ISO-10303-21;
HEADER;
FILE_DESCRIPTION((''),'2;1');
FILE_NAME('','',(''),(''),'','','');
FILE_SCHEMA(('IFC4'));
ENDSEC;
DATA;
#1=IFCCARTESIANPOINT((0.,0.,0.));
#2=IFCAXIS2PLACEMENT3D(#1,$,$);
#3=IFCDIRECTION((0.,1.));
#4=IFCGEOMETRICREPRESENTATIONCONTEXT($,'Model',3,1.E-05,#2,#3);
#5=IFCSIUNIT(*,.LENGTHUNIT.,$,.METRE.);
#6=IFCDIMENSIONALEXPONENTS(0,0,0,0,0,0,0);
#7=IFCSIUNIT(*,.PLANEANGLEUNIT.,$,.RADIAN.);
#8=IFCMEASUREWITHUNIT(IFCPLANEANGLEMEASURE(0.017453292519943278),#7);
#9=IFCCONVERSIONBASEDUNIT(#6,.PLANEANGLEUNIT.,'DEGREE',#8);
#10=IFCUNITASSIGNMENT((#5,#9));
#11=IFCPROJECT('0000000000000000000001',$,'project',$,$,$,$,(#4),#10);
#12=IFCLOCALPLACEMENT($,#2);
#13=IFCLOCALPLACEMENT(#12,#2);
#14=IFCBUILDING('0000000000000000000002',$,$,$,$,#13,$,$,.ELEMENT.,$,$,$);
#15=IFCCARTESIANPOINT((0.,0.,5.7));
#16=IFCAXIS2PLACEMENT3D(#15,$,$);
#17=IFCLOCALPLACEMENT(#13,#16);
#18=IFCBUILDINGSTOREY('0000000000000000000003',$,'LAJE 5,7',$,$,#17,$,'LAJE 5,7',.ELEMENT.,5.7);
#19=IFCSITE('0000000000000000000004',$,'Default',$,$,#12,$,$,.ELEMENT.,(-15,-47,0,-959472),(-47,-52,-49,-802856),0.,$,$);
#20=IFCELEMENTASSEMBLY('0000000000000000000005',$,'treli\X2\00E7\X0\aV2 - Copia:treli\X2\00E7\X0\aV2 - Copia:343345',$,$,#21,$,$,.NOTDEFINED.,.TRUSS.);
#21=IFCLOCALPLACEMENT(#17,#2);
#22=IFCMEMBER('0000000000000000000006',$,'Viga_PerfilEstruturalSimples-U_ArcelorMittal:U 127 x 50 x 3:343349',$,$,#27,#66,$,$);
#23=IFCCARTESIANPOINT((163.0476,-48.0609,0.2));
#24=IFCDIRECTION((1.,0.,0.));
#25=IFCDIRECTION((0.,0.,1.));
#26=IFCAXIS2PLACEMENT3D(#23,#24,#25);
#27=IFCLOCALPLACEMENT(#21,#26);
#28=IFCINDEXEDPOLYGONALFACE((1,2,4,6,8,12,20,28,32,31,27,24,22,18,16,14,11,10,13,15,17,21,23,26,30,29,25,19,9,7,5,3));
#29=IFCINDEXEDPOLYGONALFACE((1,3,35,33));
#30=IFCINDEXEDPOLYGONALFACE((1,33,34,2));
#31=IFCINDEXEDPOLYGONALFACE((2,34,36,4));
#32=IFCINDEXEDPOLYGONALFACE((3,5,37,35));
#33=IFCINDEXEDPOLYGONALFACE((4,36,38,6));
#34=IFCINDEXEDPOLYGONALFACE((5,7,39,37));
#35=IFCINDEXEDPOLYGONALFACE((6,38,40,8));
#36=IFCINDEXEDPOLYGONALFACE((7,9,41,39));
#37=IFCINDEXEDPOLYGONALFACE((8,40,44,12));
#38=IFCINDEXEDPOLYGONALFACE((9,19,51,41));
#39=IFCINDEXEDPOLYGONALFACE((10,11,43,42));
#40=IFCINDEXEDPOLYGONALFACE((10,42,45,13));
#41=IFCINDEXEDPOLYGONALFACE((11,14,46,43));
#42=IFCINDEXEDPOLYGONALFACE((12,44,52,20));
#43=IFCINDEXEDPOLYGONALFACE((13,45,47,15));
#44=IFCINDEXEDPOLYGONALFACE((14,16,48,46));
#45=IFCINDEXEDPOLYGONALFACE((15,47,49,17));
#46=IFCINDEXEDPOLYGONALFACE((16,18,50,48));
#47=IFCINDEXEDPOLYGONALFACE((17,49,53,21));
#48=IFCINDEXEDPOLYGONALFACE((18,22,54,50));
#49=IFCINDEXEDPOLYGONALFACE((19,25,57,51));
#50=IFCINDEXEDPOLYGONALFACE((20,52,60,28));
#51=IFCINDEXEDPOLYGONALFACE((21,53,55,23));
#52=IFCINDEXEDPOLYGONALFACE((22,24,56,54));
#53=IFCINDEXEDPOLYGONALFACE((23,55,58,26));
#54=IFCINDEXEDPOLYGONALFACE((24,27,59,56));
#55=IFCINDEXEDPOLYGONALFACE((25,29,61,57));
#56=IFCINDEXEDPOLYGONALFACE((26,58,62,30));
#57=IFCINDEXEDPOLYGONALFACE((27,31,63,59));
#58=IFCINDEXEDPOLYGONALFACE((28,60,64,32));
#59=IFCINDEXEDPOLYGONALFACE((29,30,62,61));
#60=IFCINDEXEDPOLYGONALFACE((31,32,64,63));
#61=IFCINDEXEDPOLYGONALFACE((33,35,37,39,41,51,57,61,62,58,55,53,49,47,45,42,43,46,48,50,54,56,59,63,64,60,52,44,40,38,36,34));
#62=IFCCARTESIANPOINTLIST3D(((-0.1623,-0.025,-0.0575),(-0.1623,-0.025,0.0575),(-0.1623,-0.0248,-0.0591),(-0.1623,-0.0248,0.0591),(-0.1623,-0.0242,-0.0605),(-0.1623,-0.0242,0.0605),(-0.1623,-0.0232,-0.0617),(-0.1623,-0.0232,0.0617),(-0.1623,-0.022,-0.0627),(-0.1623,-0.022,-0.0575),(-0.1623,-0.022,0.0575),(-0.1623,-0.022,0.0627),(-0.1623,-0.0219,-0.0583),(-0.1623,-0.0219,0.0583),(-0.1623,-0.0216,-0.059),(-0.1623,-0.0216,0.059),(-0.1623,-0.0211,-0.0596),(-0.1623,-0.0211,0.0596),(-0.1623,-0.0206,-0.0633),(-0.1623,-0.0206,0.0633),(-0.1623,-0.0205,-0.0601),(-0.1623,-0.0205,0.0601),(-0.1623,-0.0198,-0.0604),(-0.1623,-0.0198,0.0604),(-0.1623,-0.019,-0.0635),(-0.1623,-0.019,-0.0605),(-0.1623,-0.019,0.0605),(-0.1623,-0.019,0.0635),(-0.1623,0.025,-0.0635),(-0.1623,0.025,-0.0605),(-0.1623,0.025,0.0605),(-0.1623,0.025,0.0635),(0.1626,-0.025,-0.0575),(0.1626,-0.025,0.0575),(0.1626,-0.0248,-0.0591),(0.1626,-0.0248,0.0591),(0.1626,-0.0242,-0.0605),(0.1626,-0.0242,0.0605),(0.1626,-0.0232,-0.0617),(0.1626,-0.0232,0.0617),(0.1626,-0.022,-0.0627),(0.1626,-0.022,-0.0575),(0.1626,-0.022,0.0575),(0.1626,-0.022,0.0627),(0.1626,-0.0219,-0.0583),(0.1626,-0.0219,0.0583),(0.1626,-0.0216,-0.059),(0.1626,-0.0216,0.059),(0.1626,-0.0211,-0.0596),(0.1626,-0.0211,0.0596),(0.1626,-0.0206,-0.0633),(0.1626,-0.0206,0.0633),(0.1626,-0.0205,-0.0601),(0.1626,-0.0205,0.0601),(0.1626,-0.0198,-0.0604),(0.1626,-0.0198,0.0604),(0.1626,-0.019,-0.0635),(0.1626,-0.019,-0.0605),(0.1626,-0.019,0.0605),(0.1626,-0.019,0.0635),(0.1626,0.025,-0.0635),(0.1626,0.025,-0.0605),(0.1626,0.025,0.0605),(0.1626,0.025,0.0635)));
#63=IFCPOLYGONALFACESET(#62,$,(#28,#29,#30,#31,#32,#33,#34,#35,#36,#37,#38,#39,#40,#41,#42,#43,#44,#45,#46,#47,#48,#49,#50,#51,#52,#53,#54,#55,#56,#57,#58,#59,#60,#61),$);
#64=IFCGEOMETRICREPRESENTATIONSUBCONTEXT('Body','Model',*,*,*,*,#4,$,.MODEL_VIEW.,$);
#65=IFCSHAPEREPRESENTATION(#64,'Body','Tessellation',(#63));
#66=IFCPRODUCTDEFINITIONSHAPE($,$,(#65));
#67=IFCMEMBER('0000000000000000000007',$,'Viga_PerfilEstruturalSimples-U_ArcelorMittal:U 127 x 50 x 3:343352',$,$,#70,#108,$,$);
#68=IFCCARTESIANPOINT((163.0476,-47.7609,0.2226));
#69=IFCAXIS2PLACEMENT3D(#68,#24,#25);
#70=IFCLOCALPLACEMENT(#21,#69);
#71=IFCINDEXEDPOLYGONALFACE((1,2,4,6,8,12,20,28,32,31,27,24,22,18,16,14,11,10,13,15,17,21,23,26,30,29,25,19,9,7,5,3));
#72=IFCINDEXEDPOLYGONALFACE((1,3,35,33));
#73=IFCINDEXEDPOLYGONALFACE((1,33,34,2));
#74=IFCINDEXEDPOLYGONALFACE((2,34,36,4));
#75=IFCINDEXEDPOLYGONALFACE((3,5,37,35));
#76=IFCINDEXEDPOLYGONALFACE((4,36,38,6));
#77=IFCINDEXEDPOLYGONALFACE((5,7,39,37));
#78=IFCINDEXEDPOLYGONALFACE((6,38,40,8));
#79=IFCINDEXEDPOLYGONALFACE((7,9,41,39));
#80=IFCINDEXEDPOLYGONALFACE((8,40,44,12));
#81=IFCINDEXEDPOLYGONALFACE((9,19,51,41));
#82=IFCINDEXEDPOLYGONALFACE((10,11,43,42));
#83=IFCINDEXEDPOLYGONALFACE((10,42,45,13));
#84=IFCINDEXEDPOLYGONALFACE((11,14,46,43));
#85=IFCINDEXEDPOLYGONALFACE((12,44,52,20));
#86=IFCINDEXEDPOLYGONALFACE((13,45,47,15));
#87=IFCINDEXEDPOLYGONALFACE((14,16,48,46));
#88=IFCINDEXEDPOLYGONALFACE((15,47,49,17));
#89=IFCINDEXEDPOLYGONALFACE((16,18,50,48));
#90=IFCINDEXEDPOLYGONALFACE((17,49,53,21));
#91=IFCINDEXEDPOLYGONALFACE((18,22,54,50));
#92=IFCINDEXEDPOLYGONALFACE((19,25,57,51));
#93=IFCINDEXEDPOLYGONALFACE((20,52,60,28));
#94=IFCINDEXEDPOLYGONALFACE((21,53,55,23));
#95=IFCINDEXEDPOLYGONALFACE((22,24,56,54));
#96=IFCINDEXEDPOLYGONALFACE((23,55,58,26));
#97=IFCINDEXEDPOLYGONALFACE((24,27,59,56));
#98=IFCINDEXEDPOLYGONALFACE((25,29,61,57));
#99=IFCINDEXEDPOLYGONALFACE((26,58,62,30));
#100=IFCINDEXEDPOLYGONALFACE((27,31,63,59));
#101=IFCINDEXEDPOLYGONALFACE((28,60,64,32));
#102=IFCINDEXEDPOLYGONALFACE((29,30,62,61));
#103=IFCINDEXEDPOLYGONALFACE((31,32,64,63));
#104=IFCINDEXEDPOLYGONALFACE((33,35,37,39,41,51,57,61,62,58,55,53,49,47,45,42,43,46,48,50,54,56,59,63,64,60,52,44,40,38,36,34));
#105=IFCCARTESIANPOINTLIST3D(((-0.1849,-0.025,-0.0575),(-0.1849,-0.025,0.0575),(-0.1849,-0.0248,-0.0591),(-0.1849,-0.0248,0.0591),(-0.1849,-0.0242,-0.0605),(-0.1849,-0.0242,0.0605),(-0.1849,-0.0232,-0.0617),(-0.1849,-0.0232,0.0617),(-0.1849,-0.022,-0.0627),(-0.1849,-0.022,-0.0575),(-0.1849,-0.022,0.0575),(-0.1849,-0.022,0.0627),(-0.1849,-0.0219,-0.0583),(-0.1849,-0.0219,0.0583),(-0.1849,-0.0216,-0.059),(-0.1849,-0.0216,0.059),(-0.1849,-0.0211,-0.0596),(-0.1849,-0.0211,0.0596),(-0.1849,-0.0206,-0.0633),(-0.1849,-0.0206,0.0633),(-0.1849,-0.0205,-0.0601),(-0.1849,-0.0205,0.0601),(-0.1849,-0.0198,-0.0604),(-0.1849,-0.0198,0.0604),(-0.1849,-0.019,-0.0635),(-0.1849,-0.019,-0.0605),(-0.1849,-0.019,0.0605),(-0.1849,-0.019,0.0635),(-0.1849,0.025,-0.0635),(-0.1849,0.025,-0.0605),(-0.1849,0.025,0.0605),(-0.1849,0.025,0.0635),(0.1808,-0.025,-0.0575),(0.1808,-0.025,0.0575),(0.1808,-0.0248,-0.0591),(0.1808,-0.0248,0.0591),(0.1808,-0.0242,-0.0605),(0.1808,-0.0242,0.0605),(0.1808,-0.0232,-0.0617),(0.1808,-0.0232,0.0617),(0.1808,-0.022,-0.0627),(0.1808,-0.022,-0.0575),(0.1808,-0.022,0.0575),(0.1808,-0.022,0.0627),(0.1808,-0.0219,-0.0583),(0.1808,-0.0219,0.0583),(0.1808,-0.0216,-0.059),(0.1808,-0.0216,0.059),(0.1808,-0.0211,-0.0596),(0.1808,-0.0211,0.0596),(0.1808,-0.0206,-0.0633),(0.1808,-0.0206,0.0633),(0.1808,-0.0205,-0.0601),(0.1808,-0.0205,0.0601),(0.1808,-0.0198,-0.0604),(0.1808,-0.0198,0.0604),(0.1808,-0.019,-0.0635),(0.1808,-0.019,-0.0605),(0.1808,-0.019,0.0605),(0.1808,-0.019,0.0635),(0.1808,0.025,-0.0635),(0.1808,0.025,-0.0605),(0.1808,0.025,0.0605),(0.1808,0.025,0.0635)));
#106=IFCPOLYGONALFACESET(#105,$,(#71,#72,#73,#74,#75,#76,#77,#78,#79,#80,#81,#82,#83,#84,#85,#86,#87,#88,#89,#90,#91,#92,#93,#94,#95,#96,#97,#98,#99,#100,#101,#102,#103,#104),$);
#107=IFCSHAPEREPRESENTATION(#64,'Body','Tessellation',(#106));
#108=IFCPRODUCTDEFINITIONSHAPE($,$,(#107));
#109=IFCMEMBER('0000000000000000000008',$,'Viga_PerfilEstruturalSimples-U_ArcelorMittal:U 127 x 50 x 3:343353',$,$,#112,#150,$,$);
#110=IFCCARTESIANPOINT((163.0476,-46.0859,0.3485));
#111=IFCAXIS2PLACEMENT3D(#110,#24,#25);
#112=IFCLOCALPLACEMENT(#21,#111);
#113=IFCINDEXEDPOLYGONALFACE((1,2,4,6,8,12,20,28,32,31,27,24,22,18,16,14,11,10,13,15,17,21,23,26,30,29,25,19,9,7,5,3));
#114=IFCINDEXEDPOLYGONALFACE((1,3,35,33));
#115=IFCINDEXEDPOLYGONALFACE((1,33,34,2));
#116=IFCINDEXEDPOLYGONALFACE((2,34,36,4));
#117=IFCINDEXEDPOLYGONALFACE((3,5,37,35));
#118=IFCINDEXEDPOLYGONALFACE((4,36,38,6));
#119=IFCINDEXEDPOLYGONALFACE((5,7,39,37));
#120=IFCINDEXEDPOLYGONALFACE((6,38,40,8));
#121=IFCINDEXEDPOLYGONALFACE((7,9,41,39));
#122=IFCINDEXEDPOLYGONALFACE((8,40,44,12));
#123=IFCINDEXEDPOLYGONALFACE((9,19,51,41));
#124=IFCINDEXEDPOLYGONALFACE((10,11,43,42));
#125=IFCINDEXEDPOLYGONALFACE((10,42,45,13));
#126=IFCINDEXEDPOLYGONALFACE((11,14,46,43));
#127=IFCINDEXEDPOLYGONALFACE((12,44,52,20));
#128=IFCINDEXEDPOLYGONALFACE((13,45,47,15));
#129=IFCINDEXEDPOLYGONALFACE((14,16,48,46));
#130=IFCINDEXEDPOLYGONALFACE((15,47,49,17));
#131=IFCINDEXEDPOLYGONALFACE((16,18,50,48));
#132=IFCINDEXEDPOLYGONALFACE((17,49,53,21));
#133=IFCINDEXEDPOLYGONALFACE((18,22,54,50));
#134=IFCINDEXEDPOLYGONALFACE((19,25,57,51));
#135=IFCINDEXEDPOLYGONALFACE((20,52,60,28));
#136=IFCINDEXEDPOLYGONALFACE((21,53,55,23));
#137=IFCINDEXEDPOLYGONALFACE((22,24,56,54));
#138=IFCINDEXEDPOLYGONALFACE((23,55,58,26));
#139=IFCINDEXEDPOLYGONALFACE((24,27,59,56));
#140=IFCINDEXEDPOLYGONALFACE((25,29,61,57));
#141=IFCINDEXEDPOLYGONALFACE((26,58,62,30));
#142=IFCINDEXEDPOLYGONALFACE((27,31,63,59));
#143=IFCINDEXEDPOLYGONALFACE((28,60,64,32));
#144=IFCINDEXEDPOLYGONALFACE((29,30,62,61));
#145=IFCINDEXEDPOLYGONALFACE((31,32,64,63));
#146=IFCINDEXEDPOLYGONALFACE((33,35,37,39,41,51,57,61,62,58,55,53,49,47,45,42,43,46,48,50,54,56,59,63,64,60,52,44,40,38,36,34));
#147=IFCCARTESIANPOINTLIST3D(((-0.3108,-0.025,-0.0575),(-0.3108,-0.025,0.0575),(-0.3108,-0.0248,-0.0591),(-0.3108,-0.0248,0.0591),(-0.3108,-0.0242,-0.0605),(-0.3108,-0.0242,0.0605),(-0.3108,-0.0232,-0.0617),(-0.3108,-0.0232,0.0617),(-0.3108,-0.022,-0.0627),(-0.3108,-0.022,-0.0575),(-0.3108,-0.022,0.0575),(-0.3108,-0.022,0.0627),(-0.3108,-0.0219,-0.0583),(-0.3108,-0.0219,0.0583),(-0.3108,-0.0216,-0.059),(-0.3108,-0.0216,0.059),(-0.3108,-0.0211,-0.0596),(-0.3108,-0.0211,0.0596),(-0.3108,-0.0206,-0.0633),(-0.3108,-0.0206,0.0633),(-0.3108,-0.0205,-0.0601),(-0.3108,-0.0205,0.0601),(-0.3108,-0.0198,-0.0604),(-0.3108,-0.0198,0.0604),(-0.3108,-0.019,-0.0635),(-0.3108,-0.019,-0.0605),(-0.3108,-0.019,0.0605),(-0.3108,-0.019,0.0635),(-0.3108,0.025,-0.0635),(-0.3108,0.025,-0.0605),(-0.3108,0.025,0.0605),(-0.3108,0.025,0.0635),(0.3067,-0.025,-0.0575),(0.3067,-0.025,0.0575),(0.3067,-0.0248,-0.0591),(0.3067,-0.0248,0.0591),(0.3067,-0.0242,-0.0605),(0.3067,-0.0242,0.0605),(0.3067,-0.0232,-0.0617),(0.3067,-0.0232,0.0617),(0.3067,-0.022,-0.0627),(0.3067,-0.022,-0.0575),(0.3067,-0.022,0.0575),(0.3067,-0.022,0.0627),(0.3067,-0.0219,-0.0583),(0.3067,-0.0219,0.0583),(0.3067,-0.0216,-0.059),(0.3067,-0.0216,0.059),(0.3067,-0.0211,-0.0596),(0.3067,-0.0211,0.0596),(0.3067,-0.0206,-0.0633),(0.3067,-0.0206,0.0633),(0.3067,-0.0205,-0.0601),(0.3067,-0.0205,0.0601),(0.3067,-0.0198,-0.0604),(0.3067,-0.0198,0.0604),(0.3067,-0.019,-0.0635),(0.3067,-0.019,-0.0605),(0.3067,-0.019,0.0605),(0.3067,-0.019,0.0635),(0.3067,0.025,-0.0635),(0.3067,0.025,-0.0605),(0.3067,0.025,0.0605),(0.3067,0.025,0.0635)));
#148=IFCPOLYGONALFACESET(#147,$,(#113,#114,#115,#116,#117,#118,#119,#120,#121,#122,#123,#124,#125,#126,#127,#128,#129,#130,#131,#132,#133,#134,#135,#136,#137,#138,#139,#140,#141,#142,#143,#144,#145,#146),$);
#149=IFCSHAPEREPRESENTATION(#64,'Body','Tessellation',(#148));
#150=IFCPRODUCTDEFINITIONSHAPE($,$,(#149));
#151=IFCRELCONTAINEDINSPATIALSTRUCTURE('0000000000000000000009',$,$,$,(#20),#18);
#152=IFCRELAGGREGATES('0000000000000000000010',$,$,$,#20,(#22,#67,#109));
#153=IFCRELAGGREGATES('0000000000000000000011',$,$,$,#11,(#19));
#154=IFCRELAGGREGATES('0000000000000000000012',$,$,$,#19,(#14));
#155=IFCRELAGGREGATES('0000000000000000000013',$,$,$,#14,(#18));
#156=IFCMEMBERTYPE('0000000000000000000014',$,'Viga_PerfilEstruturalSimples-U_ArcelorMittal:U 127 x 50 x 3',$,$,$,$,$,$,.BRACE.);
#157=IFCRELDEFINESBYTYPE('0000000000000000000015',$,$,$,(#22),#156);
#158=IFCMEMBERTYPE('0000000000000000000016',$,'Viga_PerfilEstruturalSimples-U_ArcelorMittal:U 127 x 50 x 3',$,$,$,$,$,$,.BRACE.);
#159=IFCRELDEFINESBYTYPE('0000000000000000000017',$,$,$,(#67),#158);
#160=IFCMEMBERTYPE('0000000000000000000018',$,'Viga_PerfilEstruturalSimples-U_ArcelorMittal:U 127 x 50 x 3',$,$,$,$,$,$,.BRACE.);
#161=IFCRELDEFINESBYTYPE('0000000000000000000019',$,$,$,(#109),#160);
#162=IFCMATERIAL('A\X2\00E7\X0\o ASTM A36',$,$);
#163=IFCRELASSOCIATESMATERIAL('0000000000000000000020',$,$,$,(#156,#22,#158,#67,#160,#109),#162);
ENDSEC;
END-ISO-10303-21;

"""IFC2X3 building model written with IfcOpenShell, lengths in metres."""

from ifc_helpers import new_model, entity, si_unit, converted_unit, direction, frame, frame_2d, origin, place, context, subcontext, project, spatial, polyline, circle_curve, parameter, trimmed, segment, composite_curve, outline, extrude, source, transform, mapped, material, type_object, type_shapes, element, aggregate, save


model = new_model("IFC2X3")

# Units and contexts
model_context = context("Model", 3, precision=1e-05, world=origin(), true_north=direction((0.0, 1.0)))
body_context = subcontext(model_context, "Body", "Model", "MODEL_VIEW")
ifc_project = project(units=[si_unit("LENGTHUNIT", "METRE"), converted_unit("PLANEANGLEUNIT", "DEGREE", entity("IfcPlaneAngleMeasure", 0.017453292519943278), si_unit("PLANEANGLEUNIT", "RADIAN"), dimensions=[0, 0, 0, 0, 0, 0, 0])], contexts=[model_context])

# Site, building, storey
site_placement = place(None, origin())
site = spatial("IfcSite", under=ifc_project, at=site_placement, Name="Default", CompositionType="ELEMENT", RefLatitude=(-15, -47, 0, -959472), RefLongitude=(-47, -52, -49, -802856), RefElevation=0.0)
building_placement = place(site_placement, origin())
building = spatial("IfcBuilding", under=site, at=building_placement, CompositionType="ELEMENT")
storey_placement = place(building_placement, frame((0.0, 0.0, 5.7)))
storey = spatial("IfcBuildingStorey", under=building, at=storey_placement, Name="LAJE 5,7", LongName="LAJE 5,7", CompositionType="ELEMENT", Elevation=5.7)

# Element assembly, members
assembly_1_placement = place(storey_placement, origin())
assembly_1 = element("IfcElementAssembly", 1, at=assembly_1_placement, inside=storey, Name="treliçaV2 - Copia:treliçaV2 - Copia:343345", AssemblyPlace="NOTDEFINED", PredefinedType="TRUSS")
ifc_material = material(Name="Aço ASTM A36")
member_type_1 = type_object("IfcMemberType", Name="Viga_PerfilEstruturalSimples-U_ArcelorMittal:U 127 x 50 x 3", PredefinedType="BRACE", material=ifc_material)
shared_shape_1 = source(origin(), body_context, "Body", "SweptSolid", [
    extrude(outline(composite_curve([segment(polyline([(-0.0575, -0.0192), (0.0575, -0.0192)]), True, "CONTINUOUS"), segment(trimmed(circle_curve(frame_2d((0.0575, -0.0132), x_axis=(0.0, 1.0)), 0.006), [parameter(180.0)], [parameter(270.0)], True, "PARAMETER"), True, "CONTINUOUS"), segment(polyline([(0.0635, -0.0132), (0.0635, 0.0308)]), True, "CONTINUOUS"), segment(polyline([(0.0635, 0.0308), (0.0605, 0.0308)]), True, "CONTINUOUS"), segment(polyline([(0.0605, 0.0308), (0.0605, -0.0132)]), True, "CONTINUOUS"), segment(trimmed(circle_curve(frame_2d((0.0575, -0.0132), x_axis=(0.0, 1.0)), 0.003), [parameter(180.0)], [parameter(270.0)], True, "PARAMETER"), False, "CONTINUOUS"), segment(polyline([(0.0575, -0.0162), (-0.0575, -0.0162)]), True, "CONTINUOUS"), segment(trimmed(circle_curve(frame_2d((-0.0575, -0.0132), x_axis=(0.0, 1.0)), 0.003), [parameter(90.0)], [parameter(180.0)], True, "PARAMETER"), False, "CONTINUOUS"), segment(polyline([(-0.0605, -0.0132), (-0.0605, 0.0308)]), True, "CONTINUOUS"), segment(polyline([(-0.0605, 0.0308), (-0.0635, 0.0308)]), True, "CONTINUOUS"), segment(polyline([(-0.0635, 0.0308), (-0.0635, -0.0132)]), True, "CONTINUOUS"), segment(trimmed(circle_curve(frame_2d((-0.0575, -0.0132), x_axis=(0.0, 1.0)), 0.006), [parameter(90.0)], [parameter(180.0)], True, "PARAMETER"), True, "CONTINUOUS")], self_intersect=False)), frame((-0.1623, -0.0058, 0.0), z_axis=(1.0, 0.0, 0.0), x_axis=(0.0, 0.0, -1.0)), (0.0, 0.0, 1.0), 0.3249),
])
type_shapes(member_type_1, [shared_shape_1])
member_1_placement = place(assembly_1_placement, frame((163.0476, -48.0609, 0.2), z_axis=(1.0, 0.0, 0.0), x_axis=(0.0, 0.0, 1.0)))
member_1 = element("IfcMember", 2, at=member_1_placement, type_object=member_type_1, material=ifc_material, Name="Viga_PerfilEstruturalSimples-U_ArcelorMittal:U 127 x 50 x 3:343349", context=body_context, shape_type="MappedRepresentation", body=[
    mapped(shared_shape_1, transform((0.0, 0.0, 0.0), scale=1.0)),
])
member_type_2 = type_object("IfcMemberType", Name="Viga_PerfilEstruturalSimples-U_ArcelorMittal:U 127 x 50 x 3", PredefinedType="BRACE", material=ifc_material)
shared_shape_2 = source(origin(), body_context, "Body", "SweptSolid", [
    extrude(outline(composite_curve([segment(polyline([(-0.0575, -0.0192), (0.0575, -0.0192)]), True, "CONTINUOUS"), segment(trimmed(circle_curve(frame_2d((0.0575, -0.0132), x_axis=(0.0, 1.0)), 0.006), [parameter(180.0)], [parameter(270.0)], True, "PARAMETER"), True, "CONTINUOUS"), segment(polyline([(0.0635, -0.0132), (0.0635, 0.0308)]), True, "CONTINUOUS"), segment(polyline([(0.0635, 0.0308), (0.0605, 0.0308)]), True, "CONTINUOUS"), segment(polyline([(0.0605, 0.0308), (0.0605, -0.0132)]), True, "CONTINUOUS"), segment(trimmed(circle_curve(frame_2d((0.0575, -0.0132), x_axis=(0.0, 1.0)), 0.003), [parameter(180.0)], [parameter(270.0)], True, "PARAMETER"), False, "CONTINUOUS"), segment(polyline([(0.0575, -0.0162), (-0.0575, -0.0162)]), True, "CONTINUOUS"), segment(trimmed(circle_curve(frame_2d((-0.0575, -0.0132), x_axis=(0.0, 1.0)), 0.003), [parameter(90.0)], [parameter(180.0)], True, "PARAMETER"), False, "CONTINUOUS"), segment(polyline([(-0.0605, -0.0132), (-0.0605, 0.0308)]), True, "CONTINUOUS"), segment(polyline([(-0.0605, 0.0308), (-0.0635, 0.0308)]), True, "CONTINUOUS"), segment(polyline([(-0.0635, 0.0308), (-0.0635, -0.0132)]), True, "CONTINUOUS"), segment(trimmed(circle_curve(frame_2d((-0.0575, -0.0132), x_axis=(0.0, 1.0)), 0.006), [parameter(90.0)], [parameter(180.0)], True, "PARAMETER"), True, "CONTINUOUS")], self_intersect=False)), frame((-0.1849, -0.0058, 0.0), z_axis=(1.0, 0.0, 0.0), x_axis=(0.0, 0.0, -1.0)), (0.0, 0.0, 1.0), 0.3657),
])
type_shapes(member_type_2, [shared_shape_2])
member_2_placement = place(assembly_1_placement, frame((163.0476, -47.7609, 0.2226), z_axis=(1.0, 0.0, 0.0), x_axis=(0.0, 0.0, 1.0)))
member_2 = element("IfcMember", 3, at=member_2_placement, type_object=member_type_2, material=ifc_material, Name="Viga_PerfilEstruturalSimples-U_ArcelorMittal:U 127 x 50 x 3:343352", context=body_context, shape_type="MappedRepresentation", body=[
    mapped(shared_shape_2, transform((0.0, 0.0, 0.0), scale=1.0)),
])
member_type_3 = type_object("IfcMemberType", Name="Viga_PerfilEstruturalSimples-U_ArcelorMittal:U 127 x 50 x 3", PredefinedType="BRACE", material=ifc_material)
shared_shape_3 = source(origin(), body_context, "Body", "SweptSolid", [
    extrude(outline(composite_curve([segment(polyline([(-0.0575, -0.0192), (0.0575, -0.0192)]), True, "CONTINUOUS"), segment(trimmed(circle_curve(frame_2d((0.0575, -0.0132), x_axis=(0.0, 1.0)), 0.006), [parameter(180.0)], [parameter(270.0)], True, "PARAMETER"), True, "CONTINUOUS"), segment(polyline([(0.0635, -0.0132), (0.0635, 0.0308)]), True, "CONTINUOUS"), segment(polyline([(0.0635, 0.0308), (0.0605, 0.0308)]), True, "CONTINUOUS"), segment(polyline([(0.0605, 0.0308), (0.0605, -0.0132)]), True, "CONTINUOUS"), segment(trimmed(circle_curve(frame_2d((0.0575, -0.0132), x_axis=(0.0, 1.0)), 0.003), [parameter(180.0)], [parameter(270.0)], True, "PARAMETER"), False, "CONTINUOUS"), segment(polyline([(0.0575, -0.0162), (-0.0575, -0.0162)]), True, "CONTINUOUS"), segment(trimmed(circle_curve(frame_2d((-0.0575, -0.0132), x_axis=(0.0, 1.0)), 0.003), [parameter(90.0)], [parameter(180.0)], True, "PARAMETER"), False, "CONTINUOUS"), segment(polyline([(-0.0605, -0.0132), (-0.0605, 0.0308)]), True, "CONTINUOUS"), segment(polyline([(-0.0605, 0.0308), (-0.0635, 0.0308)]), True, "CONTINUOUS"), segment(polyline([(-0.0635, 0.0308), (-0.0635, -0.0132)]), True, "CONTINUOUS"), segment(trimmed(circle_curve(frame_2d((-0.0575, -0.0132), x_axis=(0.0, 1.0)), 0.006), [parameter(90.0)], [parameter(180.0)], True, "PARAMETER"), True, "CONTINUOUS")], self_intersect=False)), frame((-0.3108, -0.0058, 0.0), z_axis=(1.0, 0.0, 0.0), x_axis=(0.0, 0.0, -1.0)), (0.0, 0.0, 1.0), 0.6175),
])
type_shapes(member_type_3, [shared_shape_3])
member_3_placement = place(assembly_1_placement, frame((163.0476, -46.0859, 0.3485), z_axis=(1.0, 0.0, 0.0), x_axis=(0.0, 0.0, 1.0)))
member_3 = element("IfcMember", 4, at=member_3_placement, type_object=member_type_3, material=ifc_material, Name="Viga_PerfilEstruturalSimples-U_ArcelorMittal:U 127 x 50 x 3:343353", context=body_context, shape_type="MappedRepresentation", body=[
    mapped(shared_shape_3, transform((0.0, 0.0, 0.0), scale=1.0)),
])

aggregate(assembly_1, [member_1, member_2, member_3])

save(model, "model.ifc")
